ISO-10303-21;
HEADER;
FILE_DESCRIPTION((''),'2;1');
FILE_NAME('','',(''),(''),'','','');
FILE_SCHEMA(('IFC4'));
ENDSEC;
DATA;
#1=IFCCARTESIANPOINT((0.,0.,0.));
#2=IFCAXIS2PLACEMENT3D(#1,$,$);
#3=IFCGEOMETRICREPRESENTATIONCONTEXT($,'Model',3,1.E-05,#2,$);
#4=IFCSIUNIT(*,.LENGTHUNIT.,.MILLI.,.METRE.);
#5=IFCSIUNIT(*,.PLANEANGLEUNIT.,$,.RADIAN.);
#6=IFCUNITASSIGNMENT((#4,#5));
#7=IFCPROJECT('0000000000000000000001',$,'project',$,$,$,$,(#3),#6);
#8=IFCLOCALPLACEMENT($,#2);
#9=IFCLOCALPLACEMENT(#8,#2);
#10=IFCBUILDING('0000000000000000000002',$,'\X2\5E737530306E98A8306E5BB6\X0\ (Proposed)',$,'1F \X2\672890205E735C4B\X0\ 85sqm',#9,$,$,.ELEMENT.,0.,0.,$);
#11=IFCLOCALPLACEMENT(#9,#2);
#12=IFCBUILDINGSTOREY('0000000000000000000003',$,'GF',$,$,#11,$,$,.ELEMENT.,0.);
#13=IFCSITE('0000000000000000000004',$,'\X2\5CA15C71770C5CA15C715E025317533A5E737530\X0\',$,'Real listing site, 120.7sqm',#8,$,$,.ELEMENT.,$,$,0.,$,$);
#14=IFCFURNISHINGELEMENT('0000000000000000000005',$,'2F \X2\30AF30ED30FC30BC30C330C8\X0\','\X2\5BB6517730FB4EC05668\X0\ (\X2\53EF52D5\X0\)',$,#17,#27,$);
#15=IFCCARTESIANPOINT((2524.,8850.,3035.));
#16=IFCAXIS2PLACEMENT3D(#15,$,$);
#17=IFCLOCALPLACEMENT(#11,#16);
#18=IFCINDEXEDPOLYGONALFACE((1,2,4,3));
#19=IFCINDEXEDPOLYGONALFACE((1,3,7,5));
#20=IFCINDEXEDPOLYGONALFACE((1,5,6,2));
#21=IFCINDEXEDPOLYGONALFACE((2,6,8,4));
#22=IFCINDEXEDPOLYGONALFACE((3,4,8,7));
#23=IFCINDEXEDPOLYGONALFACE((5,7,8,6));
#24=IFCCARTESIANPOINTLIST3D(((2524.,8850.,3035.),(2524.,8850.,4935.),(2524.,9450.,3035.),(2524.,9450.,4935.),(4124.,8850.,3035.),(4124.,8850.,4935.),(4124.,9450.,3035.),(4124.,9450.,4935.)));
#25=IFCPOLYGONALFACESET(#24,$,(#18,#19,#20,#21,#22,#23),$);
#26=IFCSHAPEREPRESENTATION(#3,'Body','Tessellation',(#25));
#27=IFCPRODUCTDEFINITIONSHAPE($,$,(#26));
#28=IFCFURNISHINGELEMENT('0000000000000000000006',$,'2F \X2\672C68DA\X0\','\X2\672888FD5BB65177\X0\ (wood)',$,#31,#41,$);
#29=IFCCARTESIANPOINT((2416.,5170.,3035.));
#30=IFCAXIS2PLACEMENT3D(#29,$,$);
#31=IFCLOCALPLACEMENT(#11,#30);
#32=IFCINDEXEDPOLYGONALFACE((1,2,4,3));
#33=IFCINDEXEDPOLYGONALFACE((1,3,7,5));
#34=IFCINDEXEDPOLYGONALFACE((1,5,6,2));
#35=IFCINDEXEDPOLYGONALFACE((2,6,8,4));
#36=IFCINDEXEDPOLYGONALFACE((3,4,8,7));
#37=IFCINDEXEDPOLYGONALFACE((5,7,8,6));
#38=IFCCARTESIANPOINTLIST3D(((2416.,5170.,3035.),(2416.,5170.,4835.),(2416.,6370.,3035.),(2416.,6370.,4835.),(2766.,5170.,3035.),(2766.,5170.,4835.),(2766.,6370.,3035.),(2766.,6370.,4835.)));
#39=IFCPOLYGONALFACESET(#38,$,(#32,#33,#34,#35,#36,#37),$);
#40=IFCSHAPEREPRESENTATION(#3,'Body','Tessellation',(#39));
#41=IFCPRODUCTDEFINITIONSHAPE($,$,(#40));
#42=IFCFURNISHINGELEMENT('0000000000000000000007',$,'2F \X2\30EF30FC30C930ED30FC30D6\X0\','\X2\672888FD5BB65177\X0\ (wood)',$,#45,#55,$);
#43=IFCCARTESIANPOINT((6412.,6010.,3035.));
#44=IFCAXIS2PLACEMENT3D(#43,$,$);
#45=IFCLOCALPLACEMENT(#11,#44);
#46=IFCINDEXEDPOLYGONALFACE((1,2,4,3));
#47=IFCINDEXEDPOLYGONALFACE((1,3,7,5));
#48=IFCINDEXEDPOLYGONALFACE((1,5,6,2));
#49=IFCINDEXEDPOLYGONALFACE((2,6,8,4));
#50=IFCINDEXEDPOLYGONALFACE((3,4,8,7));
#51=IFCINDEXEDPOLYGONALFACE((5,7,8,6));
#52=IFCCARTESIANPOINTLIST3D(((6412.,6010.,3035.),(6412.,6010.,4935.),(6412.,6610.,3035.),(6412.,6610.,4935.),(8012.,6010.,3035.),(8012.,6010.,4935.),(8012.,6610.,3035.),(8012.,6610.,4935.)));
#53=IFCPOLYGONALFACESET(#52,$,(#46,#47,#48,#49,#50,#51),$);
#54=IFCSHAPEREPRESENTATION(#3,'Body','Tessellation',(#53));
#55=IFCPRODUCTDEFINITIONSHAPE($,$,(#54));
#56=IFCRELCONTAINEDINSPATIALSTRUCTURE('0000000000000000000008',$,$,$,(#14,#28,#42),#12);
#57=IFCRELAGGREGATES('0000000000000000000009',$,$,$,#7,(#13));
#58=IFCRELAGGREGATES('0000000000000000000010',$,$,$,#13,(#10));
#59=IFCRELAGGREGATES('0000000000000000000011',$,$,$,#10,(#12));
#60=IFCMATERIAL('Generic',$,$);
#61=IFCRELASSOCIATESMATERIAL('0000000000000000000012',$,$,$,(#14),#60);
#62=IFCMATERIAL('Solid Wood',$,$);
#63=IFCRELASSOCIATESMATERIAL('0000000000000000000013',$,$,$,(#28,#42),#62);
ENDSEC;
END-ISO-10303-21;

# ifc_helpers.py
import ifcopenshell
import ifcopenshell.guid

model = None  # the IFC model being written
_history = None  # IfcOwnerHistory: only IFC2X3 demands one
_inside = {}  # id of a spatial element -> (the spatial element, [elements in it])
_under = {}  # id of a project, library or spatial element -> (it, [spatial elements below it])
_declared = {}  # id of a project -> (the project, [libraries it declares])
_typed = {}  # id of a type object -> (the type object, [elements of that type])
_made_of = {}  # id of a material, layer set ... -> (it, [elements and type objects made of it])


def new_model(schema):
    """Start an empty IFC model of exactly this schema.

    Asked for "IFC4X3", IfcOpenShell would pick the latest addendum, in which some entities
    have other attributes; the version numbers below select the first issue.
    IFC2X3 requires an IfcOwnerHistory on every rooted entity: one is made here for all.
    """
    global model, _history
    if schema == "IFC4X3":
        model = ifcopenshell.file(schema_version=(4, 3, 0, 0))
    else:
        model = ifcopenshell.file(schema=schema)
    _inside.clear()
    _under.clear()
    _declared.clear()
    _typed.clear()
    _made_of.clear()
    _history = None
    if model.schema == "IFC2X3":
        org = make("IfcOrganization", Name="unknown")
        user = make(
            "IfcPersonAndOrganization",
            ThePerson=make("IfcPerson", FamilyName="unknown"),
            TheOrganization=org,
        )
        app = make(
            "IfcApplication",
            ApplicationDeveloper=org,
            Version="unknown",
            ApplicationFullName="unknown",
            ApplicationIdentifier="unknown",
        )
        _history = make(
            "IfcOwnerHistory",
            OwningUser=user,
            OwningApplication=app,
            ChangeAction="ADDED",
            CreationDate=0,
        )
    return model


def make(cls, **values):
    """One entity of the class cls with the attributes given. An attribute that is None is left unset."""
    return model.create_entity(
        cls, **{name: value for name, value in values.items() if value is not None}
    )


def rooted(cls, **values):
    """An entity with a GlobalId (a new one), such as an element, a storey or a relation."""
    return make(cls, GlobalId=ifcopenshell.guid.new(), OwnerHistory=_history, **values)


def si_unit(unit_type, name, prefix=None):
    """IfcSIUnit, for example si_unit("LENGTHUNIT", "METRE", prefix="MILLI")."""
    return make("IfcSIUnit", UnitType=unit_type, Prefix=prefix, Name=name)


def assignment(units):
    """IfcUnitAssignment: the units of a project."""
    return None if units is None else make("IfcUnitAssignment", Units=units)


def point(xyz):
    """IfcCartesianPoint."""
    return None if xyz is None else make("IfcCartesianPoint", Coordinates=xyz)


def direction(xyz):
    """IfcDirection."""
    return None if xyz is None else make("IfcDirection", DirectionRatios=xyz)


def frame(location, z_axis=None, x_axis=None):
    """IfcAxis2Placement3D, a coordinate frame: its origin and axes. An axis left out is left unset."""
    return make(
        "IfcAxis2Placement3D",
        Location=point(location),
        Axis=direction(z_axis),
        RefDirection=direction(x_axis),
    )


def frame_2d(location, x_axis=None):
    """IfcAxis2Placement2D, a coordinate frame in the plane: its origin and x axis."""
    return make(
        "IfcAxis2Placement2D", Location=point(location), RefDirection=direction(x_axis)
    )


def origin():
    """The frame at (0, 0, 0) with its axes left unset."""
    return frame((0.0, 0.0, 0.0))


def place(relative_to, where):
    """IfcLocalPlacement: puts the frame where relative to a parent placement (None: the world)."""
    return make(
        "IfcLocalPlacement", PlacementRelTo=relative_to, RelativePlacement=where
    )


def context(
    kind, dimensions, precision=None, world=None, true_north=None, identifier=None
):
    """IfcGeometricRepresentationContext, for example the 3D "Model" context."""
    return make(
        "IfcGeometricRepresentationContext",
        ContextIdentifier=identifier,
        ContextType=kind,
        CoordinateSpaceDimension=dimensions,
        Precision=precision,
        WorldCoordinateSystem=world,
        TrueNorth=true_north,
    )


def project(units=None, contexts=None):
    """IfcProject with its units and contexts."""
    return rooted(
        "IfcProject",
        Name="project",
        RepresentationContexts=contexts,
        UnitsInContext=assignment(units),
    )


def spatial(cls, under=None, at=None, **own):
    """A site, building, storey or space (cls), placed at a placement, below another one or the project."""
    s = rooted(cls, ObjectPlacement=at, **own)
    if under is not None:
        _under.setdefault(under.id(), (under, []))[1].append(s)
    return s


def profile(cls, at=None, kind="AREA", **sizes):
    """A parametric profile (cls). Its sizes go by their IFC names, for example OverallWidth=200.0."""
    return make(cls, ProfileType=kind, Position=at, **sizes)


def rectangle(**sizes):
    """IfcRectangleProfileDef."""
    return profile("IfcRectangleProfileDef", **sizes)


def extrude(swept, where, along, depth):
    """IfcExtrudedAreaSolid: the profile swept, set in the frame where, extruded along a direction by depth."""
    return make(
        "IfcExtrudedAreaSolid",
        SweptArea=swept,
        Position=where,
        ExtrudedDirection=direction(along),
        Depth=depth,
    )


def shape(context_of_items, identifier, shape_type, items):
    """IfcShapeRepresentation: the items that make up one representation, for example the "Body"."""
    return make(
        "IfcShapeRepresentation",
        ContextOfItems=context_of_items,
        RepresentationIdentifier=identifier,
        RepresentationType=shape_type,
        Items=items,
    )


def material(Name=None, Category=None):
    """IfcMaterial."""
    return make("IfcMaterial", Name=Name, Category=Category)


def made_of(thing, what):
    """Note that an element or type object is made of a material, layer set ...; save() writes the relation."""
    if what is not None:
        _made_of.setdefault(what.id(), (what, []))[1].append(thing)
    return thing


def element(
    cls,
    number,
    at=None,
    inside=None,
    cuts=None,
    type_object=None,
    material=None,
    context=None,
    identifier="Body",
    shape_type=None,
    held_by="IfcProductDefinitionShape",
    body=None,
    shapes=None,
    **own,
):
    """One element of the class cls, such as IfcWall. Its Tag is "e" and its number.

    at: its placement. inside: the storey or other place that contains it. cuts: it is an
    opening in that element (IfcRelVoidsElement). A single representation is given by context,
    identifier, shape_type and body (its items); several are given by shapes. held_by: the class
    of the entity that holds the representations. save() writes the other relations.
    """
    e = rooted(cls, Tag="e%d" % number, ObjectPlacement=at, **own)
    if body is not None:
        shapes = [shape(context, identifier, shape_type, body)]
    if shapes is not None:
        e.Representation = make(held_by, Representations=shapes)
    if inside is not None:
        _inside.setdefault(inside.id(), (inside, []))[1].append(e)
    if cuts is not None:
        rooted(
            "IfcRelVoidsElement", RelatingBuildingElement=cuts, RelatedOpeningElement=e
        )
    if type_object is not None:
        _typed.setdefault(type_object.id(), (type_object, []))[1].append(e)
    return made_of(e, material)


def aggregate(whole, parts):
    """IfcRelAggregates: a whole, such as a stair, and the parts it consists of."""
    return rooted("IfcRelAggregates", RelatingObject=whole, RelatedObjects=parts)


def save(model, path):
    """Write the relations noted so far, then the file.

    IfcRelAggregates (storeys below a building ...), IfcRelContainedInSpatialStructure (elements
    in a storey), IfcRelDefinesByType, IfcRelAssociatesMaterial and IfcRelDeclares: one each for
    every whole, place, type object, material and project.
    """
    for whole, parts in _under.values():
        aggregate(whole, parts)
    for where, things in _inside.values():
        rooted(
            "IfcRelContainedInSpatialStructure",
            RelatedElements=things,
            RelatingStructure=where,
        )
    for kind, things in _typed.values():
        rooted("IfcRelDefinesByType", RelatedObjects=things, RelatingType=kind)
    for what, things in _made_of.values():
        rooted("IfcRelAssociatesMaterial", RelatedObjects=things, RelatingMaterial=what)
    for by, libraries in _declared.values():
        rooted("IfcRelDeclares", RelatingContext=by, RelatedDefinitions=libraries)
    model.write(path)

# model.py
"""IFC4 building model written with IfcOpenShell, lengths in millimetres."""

from ifc_helpers import new_model, si_unit, frame, frame_2d, origin, place, context, project, spatial, rectangle, extrude, material, element, save


model = new_model("IFC4")

# Units and contexts
model_context = context("Model", 3, precision=1e-05, world=origin())
ifc_project = project(units=[si_unit("LENGTHUNIT", "METRE", prefix="MILLI"), si_unit("PLANEANGLEUNIT", "RADIAN")], contexts=[model_context])

# Site, building, storey
site_placement = place(None, origin())
site = spatial("IfcSite", under=ifc_project, at=site_placement, Name="岡山県岡山市北区平田", ObjectType="Real listing site, 120.7sqm", CompositionType="ELEMENT", RefElevation=0.0)
building_placement = place(site_placement, origin())
building = spatial("IfcBuilding", under=site, at=building_placement, Name="平田の風の家 (Proposed)", ObjectType="1F 木造平屋 85sqm", CompositionType="ELEMENT", ElevationOfRefHeight=0.0, ElevationOfTerrain=0.0)
storey_placement = place(building_placement, origin())
storey = spatial("IfcBuildingStorey", under=building, at=storey_placement, Name="GF", CompositionType="ELEMENT", Elevation=0.0)

# Shared definitions
ifc_material_1 = material(Name="Solid Wood")

# Shared definitions
ifc_material_2 = material(Name="Generic")

# Furnishing elements
furnishing_1_placement = place(storey_placement, frame((2524.0, 8850.0, 3035.0)))
element("IfcFurnishingElement", 1, at=furnishing_1_placement, inside=storey, material=ifc_material_2, Name="2F クローゼット", Description="家具・什器 (可動)", context=model_context, shape_type="SweptSolid", body=[
    extrude(rectangle(XDim=1600.0, YDim=600.0, at=frame_2d((800.0, 300.0))), frame((2524.0, 8850.0, 3035.0)), (0.0, 0.0, 1.0), 1900.0),
])
furnishing_2_placement = place(storey_placement, frame((2416.0, 5170.0, 3035.0)))
element("IfcFurnishingElement", 2, at=furnishing_2_placement, inside=storey, material=ifc_material_1, Name="2F 本棚", Description="木製家具 (wood)", context=model_context, shape_type="SweptSolid", body=[
    extrude(rectangle(XDim=350.0, YDim=1200.0, at=frame_2d((175.0, 600.0))), frame((2416.0, 5170.0, 3035.0)), (0.0, 0.0, 1.0), 1800.0),
])
furnishing_3_placement = place(storey_placement, frame((6412.0, 6010.0, 3035.0)))
element("IfcFurnishingElement", 3, at=furnishing_3_placement, inside=storey, material=ifc_material_1, Name="2F ワードローブ", Description="木製家具 (wood)", context=model_context, shape_type="SweptSolid", body=[
    extrude(rectangle(XDim=1600.0, YDim=600.0, at=frame_2d((800.0, 300.0))), frame((6412.0, 6010.0, 3035.0)), (0.0, 0.0, 1.0), 1900.0),
])

save(model, "model.ifc")
